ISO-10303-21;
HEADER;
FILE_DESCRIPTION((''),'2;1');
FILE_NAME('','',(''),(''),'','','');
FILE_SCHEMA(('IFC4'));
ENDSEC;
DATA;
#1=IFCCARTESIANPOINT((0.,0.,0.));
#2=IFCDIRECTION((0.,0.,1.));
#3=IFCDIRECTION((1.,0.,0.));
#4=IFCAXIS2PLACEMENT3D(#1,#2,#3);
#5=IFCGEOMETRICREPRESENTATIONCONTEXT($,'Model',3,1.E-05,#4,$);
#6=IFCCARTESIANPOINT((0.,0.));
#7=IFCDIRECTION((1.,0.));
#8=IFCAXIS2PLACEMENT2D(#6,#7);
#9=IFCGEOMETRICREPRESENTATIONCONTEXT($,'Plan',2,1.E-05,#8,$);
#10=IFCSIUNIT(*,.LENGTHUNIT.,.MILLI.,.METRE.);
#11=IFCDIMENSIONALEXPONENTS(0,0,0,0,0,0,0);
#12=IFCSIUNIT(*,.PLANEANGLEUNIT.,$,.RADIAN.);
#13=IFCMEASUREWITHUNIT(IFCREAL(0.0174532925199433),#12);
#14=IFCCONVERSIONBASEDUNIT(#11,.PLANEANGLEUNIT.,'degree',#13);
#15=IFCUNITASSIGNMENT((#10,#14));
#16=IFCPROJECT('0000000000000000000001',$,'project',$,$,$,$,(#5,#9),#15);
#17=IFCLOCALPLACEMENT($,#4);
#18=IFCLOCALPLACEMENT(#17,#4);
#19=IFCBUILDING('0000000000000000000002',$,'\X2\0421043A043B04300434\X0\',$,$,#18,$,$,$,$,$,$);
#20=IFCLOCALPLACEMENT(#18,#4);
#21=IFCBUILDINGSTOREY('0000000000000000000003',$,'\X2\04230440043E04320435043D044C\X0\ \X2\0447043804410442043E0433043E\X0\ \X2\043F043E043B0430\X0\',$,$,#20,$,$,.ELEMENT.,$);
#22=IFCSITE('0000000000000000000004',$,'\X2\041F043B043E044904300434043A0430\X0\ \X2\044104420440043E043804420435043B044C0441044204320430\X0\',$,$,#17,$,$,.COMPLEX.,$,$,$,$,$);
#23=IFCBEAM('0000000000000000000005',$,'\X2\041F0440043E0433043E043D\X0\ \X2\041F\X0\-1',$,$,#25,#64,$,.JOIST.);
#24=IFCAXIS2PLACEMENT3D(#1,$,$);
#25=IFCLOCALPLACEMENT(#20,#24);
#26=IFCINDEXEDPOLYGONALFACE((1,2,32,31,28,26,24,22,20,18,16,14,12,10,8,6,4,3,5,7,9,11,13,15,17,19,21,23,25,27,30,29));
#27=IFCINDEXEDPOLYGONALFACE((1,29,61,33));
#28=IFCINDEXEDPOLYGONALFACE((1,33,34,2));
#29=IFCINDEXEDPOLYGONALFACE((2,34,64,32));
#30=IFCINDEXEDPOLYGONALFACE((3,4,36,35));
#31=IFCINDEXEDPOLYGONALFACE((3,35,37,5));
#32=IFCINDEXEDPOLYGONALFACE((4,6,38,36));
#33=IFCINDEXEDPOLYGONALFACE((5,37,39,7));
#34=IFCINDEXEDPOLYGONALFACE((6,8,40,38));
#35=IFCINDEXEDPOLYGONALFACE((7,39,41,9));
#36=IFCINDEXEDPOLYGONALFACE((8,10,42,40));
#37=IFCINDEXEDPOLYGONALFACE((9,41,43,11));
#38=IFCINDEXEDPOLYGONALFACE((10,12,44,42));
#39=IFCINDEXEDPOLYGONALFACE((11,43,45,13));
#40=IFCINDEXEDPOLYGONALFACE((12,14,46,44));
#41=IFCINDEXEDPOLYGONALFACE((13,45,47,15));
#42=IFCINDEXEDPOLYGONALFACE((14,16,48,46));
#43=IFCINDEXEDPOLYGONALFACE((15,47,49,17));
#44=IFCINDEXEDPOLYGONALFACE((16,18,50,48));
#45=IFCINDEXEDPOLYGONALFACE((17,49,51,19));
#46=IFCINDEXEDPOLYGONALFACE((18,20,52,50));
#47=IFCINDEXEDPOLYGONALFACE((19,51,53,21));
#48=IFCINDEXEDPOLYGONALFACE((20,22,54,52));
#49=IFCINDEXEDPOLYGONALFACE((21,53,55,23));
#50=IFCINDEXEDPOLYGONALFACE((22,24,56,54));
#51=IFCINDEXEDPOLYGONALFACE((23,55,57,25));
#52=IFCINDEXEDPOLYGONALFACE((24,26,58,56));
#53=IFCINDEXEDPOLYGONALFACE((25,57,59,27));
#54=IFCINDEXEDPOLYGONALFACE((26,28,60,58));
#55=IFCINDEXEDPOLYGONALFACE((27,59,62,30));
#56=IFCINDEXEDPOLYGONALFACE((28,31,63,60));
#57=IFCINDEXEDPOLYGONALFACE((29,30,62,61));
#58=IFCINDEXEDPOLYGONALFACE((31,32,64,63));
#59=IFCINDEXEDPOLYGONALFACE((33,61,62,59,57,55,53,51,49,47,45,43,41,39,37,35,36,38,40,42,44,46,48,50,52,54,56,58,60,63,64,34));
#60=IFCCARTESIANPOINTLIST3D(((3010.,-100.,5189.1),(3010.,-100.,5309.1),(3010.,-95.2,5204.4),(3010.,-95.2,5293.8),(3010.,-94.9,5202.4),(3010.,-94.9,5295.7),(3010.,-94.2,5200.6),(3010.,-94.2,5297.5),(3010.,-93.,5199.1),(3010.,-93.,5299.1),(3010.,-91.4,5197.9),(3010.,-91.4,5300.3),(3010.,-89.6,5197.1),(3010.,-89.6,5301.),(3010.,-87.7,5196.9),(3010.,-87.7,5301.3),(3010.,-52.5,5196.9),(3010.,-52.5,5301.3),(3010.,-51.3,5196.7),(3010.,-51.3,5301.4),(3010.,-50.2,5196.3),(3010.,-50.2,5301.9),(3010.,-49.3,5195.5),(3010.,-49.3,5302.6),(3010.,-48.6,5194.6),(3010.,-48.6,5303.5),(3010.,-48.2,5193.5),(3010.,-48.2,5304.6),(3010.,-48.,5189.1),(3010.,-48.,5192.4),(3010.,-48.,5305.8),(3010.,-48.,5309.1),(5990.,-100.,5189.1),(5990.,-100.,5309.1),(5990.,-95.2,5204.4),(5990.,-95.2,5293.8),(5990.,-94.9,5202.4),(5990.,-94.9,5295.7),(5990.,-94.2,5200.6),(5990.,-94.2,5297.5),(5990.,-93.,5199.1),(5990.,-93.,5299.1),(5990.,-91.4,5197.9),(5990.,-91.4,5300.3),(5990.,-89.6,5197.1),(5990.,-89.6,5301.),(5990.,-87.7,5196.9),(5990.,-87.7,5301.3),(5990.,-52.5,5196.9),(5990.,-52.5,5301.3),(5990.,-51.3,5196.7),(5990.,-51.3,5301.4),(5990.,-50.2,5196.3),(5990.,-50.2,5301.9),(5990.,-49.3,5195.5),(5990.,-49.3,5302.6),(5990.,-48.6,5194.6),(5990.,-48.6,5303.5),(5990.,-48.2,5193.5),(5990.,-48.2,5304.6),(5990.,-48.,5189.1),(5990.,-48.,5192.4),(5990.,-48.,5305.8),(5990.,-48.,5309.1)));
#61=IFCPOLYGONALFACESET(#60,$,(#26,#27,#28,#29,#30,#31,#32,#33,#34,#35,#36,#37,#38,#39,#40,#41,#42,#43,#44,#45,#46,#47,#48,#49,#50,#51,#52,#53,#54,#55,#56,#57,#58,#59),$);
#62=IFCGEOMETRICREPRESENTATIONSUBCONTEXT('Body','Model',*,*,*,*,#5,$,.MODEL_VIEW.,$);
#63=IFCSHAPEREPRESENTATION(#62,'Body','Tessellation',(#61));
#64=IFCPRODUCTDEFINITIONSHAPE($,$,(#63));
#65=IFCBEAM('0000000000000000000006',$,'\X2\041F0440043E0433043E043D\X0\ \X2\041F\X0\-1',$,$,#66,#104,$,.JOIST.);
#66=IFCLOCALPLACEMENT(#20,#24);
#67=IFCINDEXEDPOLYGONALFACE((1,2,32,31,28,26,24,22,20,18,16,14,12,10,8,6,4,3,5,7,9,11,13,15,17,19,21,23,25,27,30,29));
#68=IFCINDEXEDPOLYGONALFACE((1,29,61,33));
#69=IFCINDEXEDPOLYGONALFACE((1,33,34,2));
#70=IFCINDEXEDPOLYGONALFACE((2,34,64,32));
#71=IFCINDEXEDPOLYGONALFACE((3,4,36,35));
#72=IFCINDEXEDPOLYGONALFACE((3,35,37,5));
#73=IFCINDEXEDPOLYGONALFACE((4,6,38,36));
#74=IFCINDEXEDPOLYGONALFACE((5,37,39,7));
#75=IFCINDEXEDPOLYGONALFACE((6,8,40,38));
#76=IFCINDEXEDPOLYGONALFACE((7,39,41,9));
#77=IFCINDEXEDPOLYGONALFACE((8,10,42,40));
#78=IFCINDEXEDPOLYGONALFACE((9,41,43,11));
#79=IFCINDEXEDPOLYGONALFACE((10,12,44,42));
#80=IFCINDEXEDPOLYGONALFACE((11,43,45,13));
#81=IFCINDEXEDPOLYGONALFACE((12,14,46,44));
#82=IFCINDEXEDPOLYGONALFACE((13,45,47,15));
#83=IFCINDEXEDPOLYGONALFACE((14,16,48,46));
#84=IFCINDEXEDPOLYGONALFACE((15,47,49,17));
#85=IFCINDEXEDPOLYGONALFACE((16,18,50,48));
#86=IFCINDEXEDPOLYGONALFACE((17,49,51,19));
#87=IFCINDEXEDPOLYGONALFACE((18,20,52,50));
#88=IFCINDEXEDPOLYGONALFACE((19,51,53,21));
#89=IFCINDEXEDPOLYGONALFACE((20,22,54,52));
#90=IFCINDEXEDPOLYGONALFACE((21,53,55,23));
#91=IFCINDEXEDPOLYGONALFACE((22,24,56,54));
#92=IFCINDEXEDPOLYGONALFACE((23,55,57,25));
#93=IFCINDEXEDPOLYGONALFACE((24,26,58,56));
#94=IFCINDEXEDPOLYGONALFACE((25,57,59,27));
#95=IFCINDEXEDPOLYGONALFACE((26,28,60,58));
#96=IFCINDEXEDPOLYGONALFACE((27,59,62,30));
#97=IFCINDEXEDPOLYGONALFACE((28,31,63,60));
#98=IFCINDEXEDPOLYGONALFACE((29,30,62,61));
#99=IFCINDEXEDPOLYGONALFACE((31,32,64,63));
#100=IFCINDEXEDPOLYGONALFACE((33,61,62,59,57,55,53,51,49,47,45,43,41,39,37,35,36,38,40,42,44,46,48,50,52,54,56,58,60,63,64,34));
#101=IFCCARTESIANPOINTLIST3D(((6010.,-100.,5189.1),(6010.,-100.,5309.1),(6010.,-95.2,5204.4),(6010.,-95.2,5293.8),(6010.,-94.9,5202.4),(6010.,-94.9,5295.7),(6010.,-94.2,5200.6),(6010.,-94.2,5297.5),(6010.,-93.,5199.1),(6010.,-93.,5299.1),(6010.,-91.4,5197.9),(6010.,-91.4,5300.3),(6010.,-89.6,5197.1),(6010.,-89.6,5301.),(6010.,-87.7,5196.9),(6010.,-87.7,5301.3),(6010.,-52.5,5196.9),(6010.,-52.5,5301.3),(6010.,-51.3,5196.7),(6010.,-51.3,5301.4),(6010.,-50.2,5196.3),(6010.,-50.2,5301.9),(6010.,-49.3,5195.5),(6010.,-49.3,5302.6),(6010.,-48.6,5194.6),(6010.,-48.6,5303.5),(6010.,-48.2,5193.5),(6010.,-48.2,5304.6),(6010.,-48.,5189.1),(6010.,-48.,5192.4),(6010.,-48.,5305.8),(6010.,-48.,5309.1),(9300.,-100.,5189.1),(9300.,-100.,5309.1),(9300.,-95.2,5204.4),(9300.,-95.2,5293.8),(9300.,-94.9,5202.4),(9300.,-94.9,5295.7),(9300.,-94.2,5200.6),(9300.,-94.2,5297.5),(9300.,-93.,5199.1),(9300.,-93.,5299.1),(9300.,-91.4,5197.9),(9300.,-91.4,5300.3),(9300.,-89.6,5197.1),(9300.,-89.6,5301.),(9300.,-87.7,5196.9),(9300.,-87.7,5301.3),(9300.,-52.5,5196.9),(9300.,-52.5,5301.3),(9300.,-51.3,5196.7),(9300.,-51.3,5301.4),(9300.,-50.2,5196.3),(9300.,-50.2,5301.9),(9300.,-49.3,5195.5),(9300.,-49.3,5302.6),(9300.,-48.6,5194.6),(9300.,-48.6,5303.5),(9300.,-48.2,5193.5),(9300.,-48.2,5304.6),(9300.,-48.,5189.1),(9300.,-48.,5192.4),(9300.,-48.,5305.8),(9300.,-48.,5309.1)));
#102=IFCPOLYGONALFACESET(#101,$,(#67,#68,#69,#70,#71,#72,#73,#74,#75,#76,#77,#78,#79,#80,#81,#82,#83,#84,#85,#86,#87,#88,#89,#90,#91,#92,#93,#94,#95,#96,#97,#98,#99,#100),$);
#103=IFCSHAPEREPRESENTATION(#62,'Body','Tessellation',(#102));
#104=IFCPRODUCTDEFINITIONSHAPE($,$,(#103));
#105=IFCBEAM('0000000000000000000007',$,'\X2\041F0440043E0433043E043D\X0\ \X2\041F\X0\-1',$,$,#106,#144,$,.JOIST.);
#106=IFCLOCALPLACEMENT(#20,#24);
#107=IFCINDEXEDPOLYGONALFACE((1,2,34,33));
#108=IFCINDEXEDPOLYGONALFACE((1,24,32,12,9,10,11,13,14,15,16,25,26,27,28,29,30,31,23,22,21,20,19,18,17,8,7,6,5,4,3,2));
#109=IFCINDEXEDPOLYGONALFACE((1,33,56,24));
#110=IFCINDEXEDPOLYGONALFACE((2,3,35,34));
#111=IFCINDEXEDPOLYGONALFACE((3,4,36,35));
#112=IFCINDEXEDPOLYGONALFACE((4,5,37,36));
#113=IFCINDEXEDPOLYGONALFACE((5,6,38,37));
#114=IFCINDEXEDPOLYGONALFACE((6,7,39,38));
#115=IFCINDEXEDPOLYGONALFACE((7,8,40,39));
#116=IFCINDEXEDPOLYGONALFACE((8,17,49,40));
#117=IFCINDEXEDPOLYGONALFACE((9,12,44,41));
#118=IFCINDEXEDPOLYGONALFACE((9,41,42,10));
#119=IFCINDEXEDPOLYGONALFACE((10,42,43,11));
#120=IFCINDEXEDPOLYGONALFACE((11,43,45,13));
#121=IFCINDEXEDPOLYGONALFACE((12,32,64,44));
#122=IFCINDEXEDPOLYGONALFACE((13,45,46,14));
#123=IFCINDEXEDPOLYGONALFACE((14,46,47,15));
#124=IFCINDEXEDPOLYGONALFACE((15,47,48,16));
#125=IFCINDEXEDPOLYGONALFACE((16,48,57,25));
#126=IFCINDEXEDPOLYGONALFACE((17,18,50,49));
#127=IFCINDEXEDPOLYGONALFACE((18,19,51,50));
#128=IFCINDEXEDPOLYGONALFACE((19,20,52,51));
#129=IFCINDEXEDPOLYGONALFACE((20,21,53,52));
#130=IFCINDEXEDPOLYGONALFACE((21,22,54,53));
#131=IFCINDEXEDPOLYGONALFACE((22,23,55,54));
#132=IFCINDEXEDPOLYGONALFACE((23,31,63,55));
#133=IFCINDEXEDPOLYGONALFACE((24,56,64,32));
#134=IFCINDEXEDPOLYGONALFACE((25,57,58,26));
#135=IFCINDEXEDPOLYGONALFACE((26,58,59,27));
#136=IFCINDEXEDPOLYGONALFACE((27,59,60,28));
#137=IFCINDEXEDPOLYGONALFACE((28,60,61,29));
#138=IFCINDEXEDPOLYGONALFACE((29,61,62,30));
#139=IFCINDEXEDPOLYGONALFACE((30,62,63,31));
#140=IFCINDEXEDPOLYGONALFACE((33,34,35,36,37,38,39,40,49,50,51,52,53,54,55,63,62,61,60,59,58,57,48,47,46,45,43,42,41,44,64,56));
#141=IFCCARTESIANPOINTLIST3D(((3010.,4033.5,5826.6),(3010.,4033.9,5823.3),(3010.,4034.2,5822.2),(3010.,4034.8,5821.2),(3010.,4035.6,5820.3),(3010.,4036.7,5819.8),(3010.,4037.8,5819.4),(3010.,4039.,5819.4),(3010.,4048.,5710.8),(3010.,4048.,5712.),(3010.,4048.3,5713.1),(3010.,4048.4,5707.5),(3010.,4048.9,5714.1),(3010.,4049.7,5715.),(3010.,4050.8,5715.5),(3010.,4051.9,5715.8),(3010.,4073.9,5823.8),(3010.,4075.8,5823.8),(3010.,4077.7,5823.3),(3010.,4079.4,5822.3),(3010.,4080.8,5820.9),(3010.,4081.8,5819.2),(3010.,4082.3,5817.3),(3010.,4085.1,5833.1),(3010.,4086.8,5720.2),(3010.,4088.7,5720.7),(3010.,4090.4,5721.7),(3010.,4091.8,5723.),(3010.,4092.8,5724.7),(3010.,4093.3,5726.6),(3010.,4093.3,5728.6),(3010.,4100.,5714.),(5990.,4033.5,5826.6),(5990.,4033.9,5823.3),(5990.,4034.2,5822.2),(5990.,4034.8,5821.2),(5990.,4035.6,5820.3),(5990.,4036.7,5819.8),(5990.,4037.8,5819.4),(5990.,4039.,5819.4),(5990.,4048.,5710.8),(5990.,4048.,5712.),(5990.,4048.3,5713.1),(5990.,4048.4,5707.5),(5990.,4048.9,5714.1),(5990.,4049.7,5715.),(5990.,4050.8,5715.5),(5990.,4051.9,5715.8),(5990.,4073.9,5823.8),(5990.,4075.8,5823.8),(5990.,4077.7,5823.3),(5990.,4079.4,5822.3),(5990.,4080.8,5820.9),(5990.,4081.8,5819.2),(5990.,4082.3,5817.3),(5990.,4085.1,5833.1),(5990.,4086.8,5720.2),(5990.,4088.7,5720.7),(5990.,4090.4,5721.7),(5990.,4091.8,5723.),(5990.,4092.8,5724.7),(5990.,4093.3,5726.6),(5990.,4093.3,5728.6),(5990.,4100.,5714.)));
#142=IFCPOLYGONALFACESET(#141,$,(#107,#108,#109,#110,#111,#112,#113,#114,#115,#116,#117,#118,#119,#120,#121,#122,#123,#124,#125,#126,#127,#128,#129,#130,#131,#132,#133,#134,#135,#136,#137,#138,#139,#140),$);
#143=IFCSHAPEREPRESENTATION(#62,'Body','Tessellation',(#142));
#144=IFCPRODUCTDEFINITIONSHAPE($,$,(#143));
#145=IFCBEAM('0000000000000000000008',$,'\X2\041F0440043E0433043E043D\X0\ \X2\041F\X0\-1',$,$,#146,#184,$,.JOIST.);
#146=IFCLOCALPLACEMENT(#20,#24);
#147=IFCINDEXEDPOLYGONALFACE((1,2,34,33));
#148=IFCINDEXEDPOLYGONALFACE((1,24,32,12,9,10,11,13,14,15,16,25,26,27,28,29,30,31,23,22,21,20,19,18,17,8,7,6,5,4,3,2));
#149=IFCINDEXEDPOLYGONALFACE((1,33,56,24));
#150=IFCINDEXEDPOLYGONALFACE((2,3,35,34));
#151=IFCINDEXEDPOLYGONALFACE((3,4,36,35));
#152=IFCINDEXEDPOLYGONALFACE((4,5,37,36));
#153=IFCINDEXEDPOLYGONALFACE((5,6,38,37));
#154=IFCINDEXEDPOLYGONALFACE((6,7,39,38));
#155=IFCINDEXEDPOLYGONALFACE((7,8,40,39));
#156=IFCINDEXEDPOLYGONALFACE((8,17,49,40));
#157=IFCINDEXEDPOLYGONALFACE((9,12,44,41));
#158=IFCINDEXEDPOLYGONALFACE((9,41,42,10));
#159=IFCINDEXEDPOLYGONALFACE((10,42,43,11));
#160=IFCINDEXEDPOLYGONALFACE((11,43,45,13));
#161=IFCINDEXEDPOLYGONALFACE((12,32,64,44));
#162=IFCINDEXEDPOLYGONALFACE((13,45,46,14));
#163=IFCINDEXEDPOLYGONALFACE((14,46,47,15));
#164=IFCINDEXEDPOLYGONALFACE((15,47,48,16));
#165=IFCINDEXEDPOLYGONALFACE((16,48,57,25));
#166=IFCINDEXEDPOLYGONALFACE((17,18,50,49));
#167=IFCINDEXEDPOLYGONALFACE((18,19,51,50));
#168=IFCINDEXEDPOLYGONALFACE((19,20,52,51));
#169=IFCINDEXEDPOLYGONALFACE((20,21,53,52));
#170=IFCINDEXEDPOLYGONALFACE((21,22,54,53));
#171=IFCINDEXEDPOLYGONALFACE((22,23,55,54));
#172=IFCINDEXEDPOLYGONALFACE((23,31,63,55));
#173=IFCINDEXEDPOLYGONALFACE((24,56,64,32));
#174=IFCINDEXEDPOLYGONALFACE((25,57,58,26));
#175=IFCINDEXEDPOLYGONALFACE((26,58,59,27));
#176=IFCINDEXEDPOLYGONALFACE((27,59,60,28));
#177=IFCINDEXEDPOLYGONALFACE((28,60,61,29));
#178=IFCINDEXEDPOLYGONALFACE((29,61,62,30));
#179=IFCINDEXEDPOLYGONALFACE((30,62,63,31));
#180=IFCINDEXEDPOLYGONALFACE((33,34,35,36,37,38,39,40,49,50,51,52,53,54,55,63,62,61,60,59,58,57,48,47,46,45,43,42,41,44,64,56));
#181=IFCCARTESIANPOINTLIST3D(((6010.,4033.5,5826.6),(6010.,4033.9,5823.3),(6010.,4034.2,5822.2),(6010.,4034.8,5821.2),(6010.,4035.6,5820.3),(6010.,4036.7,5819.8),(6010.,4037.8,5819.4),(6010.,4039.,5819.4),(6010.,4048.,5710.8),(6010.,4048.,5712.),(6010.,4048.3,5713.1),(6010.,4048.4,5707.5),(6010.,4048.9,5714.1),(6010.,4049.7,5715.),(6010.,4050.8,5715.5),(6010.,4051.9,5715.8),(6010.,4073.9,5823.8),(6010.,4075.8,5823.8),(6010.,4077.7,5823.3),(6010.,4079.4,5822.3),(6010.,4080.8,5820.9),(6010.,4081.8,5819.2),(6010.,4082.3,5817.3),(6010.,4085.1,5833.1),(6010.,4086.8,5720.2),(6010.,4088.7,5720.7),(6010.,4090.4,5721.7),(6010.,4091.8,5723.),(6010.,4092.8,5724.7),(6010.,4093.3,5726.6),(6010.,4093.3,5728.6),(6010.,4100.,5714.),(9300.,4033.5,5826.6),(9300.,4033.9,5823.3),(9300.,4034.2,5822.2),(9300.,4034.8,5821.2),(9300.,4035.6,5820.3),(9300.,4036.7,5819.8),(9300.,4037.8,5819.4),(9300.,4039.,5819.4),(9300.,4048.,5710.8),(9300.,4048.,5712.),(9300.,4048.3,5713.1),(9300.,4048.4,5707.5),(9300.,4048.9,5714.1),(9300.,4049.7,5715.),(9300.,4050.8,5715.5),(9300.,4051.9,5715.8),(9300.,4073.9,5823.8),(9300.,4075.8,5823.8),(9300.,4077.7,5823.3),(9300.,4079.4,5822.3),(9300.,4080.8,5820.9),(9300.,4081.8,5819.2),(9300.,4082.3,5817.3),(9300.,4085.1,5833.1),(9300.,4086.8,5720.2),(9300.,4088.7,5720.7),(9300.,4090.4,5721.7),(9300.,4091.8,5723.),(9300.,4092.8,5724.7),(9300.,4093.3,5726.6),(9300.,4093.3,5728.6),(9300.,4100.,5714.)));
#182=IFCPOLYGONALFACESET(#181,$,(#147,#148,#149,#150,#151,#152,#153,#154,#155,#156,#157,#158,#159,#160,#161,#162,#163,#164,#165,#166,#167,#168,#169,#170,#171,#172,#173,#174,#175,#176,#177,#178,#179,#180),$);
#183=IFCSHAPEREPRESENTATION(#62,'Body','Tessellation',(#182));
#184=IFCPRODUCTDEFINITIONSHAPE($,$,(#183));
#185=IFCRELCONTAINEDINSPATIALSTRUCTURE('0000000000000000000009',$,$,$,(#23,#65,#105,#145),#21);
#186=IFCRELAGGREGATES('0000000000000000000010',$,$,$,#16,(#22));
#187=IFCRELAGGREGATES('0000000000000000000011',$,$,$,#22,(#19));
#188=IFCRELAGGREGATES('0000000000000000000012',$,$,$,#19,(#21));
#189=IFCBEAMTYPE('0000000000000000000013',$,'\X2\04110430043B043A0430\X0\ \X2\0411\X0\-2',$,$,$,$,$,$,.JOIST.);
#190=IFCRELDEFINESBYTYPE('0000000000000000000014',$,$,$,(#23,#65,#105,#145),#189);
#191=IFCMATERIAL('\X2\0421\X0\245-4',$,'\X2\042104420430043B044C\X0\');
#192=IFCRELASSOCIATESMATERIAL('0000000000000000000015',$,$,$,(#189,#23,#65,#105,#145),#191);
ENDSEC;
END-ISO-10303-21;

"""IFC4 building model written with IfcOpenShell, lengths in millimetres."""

from ifc_helpers import new_model, entity, si_unit, converted_unit, frame, origin_with_axes, origin_2d_with_axis, place, context, subcontext, project, spatial, u_section, extrude, material, material_profile, profile_set, profile_usage, type_object, element, save


model = new_model("IFC4")

# Units and contexts
model_context = context("Model", 3, precision=1e-05, world=origin_with_axes())
plan_context = context("Plan", 2, precision=1e-05, world=origin_2d_with_axis())
body_context = subcontext(model_context, "Body", "Model", "MODEL_VIEW")
ifc_project = project(units=[si_unit("LENGTHUNIT", "METRE", prefix="MILLI"), converted_unit("PLANEANGLEUNIT", "degree", entity("IfcReal", 0.0174532925199433), si_unit("PLANEANGLEUNIT", "RADIAN"), dimensions=[0, 0, 0, 0, 0, 0, 0])], contexts=[model_context, plan_context])

# Site, building, storey
site_placement = place(None, origin_with_axes())
site = spatial("IfcSite", under=ifc_project, at=site_placement, Name="Площадка строительства", CompositionType="COMPLEX")
building_placement = place(site_placement, origin_with_axes())
building = spatial("IfcBuilding", under=site, at=building_placement, Name="Склад")
storey_placement = place(building_placement, origin_with_axes())
storey = spatial("IfcBuildingStorey", under=building, at=storey_placement, Name="Уровень чистого пола", CompositionType="ELEMENT")

# Beams
ifc_material_1 = material(Name="С245-4", Category="Сталь")
ifc_material_profile_1 = material_profile(ifc_material_1, u_section(Depth=120.0, FlangeWidth=52.0, WebThickness=4.8, FlangeThickness=7.8, FilletRadius=7.5, EdgeRadius=4.5, FlangeSlope=0.0))
ifc_profile_set_1 = profile_set([ifc_material_profile_1], Name="U12P_S245-4")
ifc_profile_usage_1 = profile_usage(ifc_profile_set_1, cardinal=3)
beam_type_1 = type_object("IfcBeamType", Name="Балка Б-2", PredefinedType="JOIST", material=ifc_profile_set_1)
beam_1_placement = place(storey_placement, frame((3010.0, -100.0, 5189.1), z_axis=(1.0, 0.0, 0.0), x_axis=(0.0, 1.0, 0.0)))
element("IfcBeam", 1, at=beam_1_placement, inside=storey, type_object=beam_type_1, material=ifc_profile_usage_1, Name="Прогон П-1", PredefinedType="JOIST", context=body_context, shape_type="SweptSolid", body=[
    extrude(u_section(Depth=120.0, FlangeWidth=52.0, WebThickness=4.8, FlangeThickness=7.8, FilletRadius=7.5, EdgeRadius=4.5, FlangeSlope=0.0), frame((26.0, 60.0, 0.0), z_axis=(0.0, 0.0, 1.0), x_axis=(1.0, 0.0, 0.0)), (0.0, 0.0, 1.0), 2980.0),
])
beam_2_placement = place(storey_placement, frame((6010.0, -100.0, 5189.1), z_axis=(1.0, 0.0, 0.0), x_axis=(0.0, 1.0, 0.0)))
element("IfcBeam", 2, at=beam_2_placement, inside=storey, type_object=beam_type_1, material=ifc_profile_usage_1, Name="Прогон П-1", PredefinedType="JOIST", context=body_context, shape_type="SweptSolid", body=[
    extrude(u_section(Depth=120.0, FlangeWidth=52.0, WebThickness=4.8, FlangeThickness=7.8, FilletRadius=7.5, EdgeRadius=4.5, FlangeSlope=0.0), frame((26.0, 60.0, 0.0), z_axis=(0.0, 0.0, 1.0), x_axis=(1.0, 0.0, 0.0)), (0.0, 0.0, 1.0), 3290.0),
])
beam_3_placement = place(storey_placement, frame((5990.0, 4100.0, 5714.0), z_axis=(-1.0, 0.0, 0.0), x_axis=(0.0, -0.99228, -0.12402)))
element("IfcBeam", 3, at=beam_3_placement, inside=storey, type_object=beam_type_1, material=ifc_profile_usage_1, Name="Прогон П-1", PredefinedType="JOIST", context=body_context, shape_type="SweptSolid", body=[
    extrude(u_section(Depth=120.0, FlangeWidth=52.0, WebThickness=4.8, FlangeThickness=7.8, FilletRadius=7.5, EdgeRadius=4.5, FlangeSlope=0.0), frame((26.0, 60.0, 0.0), z_axis=(0.0, 0.0, 1.0), x_axis=(1.0, 0.0, 0.0)), (0.0, 0.0, 1.0), 2980.0),
])
beam_4_placement = place(storey_placement, frame((9300.0, 4100.0, 5714.0), z_axis=(-1.0, 0.0, 0.0), x_axis=(0.0, -0.99228, -0.12402)))
element("IfcBeam", 4, at=beam_4_placement, inside=storey, type_object=beam_type_1, material=ifc_profile_usage_1, Name="Прогон П-1", PredefinedType="JOIST", context=body_context, shape_type="SweptSolid", body=[
    extrude(u_section(Depth=120.0, FlangeWidth=52.0, WebThickness=4.8, FlangeThickness=7.8, FilletRadius=7.5, EdgeRadius=4.5, FlangeSlope=0.0), frame((26.0, 60.0, 0.0), z_axis=(0.0, 0.0, 1.0), x_axis=(1.0, 0.0, 0.0)), (0.0, 0.0, 1.0), 3290.0),
])

save(model, "model.ifc")
